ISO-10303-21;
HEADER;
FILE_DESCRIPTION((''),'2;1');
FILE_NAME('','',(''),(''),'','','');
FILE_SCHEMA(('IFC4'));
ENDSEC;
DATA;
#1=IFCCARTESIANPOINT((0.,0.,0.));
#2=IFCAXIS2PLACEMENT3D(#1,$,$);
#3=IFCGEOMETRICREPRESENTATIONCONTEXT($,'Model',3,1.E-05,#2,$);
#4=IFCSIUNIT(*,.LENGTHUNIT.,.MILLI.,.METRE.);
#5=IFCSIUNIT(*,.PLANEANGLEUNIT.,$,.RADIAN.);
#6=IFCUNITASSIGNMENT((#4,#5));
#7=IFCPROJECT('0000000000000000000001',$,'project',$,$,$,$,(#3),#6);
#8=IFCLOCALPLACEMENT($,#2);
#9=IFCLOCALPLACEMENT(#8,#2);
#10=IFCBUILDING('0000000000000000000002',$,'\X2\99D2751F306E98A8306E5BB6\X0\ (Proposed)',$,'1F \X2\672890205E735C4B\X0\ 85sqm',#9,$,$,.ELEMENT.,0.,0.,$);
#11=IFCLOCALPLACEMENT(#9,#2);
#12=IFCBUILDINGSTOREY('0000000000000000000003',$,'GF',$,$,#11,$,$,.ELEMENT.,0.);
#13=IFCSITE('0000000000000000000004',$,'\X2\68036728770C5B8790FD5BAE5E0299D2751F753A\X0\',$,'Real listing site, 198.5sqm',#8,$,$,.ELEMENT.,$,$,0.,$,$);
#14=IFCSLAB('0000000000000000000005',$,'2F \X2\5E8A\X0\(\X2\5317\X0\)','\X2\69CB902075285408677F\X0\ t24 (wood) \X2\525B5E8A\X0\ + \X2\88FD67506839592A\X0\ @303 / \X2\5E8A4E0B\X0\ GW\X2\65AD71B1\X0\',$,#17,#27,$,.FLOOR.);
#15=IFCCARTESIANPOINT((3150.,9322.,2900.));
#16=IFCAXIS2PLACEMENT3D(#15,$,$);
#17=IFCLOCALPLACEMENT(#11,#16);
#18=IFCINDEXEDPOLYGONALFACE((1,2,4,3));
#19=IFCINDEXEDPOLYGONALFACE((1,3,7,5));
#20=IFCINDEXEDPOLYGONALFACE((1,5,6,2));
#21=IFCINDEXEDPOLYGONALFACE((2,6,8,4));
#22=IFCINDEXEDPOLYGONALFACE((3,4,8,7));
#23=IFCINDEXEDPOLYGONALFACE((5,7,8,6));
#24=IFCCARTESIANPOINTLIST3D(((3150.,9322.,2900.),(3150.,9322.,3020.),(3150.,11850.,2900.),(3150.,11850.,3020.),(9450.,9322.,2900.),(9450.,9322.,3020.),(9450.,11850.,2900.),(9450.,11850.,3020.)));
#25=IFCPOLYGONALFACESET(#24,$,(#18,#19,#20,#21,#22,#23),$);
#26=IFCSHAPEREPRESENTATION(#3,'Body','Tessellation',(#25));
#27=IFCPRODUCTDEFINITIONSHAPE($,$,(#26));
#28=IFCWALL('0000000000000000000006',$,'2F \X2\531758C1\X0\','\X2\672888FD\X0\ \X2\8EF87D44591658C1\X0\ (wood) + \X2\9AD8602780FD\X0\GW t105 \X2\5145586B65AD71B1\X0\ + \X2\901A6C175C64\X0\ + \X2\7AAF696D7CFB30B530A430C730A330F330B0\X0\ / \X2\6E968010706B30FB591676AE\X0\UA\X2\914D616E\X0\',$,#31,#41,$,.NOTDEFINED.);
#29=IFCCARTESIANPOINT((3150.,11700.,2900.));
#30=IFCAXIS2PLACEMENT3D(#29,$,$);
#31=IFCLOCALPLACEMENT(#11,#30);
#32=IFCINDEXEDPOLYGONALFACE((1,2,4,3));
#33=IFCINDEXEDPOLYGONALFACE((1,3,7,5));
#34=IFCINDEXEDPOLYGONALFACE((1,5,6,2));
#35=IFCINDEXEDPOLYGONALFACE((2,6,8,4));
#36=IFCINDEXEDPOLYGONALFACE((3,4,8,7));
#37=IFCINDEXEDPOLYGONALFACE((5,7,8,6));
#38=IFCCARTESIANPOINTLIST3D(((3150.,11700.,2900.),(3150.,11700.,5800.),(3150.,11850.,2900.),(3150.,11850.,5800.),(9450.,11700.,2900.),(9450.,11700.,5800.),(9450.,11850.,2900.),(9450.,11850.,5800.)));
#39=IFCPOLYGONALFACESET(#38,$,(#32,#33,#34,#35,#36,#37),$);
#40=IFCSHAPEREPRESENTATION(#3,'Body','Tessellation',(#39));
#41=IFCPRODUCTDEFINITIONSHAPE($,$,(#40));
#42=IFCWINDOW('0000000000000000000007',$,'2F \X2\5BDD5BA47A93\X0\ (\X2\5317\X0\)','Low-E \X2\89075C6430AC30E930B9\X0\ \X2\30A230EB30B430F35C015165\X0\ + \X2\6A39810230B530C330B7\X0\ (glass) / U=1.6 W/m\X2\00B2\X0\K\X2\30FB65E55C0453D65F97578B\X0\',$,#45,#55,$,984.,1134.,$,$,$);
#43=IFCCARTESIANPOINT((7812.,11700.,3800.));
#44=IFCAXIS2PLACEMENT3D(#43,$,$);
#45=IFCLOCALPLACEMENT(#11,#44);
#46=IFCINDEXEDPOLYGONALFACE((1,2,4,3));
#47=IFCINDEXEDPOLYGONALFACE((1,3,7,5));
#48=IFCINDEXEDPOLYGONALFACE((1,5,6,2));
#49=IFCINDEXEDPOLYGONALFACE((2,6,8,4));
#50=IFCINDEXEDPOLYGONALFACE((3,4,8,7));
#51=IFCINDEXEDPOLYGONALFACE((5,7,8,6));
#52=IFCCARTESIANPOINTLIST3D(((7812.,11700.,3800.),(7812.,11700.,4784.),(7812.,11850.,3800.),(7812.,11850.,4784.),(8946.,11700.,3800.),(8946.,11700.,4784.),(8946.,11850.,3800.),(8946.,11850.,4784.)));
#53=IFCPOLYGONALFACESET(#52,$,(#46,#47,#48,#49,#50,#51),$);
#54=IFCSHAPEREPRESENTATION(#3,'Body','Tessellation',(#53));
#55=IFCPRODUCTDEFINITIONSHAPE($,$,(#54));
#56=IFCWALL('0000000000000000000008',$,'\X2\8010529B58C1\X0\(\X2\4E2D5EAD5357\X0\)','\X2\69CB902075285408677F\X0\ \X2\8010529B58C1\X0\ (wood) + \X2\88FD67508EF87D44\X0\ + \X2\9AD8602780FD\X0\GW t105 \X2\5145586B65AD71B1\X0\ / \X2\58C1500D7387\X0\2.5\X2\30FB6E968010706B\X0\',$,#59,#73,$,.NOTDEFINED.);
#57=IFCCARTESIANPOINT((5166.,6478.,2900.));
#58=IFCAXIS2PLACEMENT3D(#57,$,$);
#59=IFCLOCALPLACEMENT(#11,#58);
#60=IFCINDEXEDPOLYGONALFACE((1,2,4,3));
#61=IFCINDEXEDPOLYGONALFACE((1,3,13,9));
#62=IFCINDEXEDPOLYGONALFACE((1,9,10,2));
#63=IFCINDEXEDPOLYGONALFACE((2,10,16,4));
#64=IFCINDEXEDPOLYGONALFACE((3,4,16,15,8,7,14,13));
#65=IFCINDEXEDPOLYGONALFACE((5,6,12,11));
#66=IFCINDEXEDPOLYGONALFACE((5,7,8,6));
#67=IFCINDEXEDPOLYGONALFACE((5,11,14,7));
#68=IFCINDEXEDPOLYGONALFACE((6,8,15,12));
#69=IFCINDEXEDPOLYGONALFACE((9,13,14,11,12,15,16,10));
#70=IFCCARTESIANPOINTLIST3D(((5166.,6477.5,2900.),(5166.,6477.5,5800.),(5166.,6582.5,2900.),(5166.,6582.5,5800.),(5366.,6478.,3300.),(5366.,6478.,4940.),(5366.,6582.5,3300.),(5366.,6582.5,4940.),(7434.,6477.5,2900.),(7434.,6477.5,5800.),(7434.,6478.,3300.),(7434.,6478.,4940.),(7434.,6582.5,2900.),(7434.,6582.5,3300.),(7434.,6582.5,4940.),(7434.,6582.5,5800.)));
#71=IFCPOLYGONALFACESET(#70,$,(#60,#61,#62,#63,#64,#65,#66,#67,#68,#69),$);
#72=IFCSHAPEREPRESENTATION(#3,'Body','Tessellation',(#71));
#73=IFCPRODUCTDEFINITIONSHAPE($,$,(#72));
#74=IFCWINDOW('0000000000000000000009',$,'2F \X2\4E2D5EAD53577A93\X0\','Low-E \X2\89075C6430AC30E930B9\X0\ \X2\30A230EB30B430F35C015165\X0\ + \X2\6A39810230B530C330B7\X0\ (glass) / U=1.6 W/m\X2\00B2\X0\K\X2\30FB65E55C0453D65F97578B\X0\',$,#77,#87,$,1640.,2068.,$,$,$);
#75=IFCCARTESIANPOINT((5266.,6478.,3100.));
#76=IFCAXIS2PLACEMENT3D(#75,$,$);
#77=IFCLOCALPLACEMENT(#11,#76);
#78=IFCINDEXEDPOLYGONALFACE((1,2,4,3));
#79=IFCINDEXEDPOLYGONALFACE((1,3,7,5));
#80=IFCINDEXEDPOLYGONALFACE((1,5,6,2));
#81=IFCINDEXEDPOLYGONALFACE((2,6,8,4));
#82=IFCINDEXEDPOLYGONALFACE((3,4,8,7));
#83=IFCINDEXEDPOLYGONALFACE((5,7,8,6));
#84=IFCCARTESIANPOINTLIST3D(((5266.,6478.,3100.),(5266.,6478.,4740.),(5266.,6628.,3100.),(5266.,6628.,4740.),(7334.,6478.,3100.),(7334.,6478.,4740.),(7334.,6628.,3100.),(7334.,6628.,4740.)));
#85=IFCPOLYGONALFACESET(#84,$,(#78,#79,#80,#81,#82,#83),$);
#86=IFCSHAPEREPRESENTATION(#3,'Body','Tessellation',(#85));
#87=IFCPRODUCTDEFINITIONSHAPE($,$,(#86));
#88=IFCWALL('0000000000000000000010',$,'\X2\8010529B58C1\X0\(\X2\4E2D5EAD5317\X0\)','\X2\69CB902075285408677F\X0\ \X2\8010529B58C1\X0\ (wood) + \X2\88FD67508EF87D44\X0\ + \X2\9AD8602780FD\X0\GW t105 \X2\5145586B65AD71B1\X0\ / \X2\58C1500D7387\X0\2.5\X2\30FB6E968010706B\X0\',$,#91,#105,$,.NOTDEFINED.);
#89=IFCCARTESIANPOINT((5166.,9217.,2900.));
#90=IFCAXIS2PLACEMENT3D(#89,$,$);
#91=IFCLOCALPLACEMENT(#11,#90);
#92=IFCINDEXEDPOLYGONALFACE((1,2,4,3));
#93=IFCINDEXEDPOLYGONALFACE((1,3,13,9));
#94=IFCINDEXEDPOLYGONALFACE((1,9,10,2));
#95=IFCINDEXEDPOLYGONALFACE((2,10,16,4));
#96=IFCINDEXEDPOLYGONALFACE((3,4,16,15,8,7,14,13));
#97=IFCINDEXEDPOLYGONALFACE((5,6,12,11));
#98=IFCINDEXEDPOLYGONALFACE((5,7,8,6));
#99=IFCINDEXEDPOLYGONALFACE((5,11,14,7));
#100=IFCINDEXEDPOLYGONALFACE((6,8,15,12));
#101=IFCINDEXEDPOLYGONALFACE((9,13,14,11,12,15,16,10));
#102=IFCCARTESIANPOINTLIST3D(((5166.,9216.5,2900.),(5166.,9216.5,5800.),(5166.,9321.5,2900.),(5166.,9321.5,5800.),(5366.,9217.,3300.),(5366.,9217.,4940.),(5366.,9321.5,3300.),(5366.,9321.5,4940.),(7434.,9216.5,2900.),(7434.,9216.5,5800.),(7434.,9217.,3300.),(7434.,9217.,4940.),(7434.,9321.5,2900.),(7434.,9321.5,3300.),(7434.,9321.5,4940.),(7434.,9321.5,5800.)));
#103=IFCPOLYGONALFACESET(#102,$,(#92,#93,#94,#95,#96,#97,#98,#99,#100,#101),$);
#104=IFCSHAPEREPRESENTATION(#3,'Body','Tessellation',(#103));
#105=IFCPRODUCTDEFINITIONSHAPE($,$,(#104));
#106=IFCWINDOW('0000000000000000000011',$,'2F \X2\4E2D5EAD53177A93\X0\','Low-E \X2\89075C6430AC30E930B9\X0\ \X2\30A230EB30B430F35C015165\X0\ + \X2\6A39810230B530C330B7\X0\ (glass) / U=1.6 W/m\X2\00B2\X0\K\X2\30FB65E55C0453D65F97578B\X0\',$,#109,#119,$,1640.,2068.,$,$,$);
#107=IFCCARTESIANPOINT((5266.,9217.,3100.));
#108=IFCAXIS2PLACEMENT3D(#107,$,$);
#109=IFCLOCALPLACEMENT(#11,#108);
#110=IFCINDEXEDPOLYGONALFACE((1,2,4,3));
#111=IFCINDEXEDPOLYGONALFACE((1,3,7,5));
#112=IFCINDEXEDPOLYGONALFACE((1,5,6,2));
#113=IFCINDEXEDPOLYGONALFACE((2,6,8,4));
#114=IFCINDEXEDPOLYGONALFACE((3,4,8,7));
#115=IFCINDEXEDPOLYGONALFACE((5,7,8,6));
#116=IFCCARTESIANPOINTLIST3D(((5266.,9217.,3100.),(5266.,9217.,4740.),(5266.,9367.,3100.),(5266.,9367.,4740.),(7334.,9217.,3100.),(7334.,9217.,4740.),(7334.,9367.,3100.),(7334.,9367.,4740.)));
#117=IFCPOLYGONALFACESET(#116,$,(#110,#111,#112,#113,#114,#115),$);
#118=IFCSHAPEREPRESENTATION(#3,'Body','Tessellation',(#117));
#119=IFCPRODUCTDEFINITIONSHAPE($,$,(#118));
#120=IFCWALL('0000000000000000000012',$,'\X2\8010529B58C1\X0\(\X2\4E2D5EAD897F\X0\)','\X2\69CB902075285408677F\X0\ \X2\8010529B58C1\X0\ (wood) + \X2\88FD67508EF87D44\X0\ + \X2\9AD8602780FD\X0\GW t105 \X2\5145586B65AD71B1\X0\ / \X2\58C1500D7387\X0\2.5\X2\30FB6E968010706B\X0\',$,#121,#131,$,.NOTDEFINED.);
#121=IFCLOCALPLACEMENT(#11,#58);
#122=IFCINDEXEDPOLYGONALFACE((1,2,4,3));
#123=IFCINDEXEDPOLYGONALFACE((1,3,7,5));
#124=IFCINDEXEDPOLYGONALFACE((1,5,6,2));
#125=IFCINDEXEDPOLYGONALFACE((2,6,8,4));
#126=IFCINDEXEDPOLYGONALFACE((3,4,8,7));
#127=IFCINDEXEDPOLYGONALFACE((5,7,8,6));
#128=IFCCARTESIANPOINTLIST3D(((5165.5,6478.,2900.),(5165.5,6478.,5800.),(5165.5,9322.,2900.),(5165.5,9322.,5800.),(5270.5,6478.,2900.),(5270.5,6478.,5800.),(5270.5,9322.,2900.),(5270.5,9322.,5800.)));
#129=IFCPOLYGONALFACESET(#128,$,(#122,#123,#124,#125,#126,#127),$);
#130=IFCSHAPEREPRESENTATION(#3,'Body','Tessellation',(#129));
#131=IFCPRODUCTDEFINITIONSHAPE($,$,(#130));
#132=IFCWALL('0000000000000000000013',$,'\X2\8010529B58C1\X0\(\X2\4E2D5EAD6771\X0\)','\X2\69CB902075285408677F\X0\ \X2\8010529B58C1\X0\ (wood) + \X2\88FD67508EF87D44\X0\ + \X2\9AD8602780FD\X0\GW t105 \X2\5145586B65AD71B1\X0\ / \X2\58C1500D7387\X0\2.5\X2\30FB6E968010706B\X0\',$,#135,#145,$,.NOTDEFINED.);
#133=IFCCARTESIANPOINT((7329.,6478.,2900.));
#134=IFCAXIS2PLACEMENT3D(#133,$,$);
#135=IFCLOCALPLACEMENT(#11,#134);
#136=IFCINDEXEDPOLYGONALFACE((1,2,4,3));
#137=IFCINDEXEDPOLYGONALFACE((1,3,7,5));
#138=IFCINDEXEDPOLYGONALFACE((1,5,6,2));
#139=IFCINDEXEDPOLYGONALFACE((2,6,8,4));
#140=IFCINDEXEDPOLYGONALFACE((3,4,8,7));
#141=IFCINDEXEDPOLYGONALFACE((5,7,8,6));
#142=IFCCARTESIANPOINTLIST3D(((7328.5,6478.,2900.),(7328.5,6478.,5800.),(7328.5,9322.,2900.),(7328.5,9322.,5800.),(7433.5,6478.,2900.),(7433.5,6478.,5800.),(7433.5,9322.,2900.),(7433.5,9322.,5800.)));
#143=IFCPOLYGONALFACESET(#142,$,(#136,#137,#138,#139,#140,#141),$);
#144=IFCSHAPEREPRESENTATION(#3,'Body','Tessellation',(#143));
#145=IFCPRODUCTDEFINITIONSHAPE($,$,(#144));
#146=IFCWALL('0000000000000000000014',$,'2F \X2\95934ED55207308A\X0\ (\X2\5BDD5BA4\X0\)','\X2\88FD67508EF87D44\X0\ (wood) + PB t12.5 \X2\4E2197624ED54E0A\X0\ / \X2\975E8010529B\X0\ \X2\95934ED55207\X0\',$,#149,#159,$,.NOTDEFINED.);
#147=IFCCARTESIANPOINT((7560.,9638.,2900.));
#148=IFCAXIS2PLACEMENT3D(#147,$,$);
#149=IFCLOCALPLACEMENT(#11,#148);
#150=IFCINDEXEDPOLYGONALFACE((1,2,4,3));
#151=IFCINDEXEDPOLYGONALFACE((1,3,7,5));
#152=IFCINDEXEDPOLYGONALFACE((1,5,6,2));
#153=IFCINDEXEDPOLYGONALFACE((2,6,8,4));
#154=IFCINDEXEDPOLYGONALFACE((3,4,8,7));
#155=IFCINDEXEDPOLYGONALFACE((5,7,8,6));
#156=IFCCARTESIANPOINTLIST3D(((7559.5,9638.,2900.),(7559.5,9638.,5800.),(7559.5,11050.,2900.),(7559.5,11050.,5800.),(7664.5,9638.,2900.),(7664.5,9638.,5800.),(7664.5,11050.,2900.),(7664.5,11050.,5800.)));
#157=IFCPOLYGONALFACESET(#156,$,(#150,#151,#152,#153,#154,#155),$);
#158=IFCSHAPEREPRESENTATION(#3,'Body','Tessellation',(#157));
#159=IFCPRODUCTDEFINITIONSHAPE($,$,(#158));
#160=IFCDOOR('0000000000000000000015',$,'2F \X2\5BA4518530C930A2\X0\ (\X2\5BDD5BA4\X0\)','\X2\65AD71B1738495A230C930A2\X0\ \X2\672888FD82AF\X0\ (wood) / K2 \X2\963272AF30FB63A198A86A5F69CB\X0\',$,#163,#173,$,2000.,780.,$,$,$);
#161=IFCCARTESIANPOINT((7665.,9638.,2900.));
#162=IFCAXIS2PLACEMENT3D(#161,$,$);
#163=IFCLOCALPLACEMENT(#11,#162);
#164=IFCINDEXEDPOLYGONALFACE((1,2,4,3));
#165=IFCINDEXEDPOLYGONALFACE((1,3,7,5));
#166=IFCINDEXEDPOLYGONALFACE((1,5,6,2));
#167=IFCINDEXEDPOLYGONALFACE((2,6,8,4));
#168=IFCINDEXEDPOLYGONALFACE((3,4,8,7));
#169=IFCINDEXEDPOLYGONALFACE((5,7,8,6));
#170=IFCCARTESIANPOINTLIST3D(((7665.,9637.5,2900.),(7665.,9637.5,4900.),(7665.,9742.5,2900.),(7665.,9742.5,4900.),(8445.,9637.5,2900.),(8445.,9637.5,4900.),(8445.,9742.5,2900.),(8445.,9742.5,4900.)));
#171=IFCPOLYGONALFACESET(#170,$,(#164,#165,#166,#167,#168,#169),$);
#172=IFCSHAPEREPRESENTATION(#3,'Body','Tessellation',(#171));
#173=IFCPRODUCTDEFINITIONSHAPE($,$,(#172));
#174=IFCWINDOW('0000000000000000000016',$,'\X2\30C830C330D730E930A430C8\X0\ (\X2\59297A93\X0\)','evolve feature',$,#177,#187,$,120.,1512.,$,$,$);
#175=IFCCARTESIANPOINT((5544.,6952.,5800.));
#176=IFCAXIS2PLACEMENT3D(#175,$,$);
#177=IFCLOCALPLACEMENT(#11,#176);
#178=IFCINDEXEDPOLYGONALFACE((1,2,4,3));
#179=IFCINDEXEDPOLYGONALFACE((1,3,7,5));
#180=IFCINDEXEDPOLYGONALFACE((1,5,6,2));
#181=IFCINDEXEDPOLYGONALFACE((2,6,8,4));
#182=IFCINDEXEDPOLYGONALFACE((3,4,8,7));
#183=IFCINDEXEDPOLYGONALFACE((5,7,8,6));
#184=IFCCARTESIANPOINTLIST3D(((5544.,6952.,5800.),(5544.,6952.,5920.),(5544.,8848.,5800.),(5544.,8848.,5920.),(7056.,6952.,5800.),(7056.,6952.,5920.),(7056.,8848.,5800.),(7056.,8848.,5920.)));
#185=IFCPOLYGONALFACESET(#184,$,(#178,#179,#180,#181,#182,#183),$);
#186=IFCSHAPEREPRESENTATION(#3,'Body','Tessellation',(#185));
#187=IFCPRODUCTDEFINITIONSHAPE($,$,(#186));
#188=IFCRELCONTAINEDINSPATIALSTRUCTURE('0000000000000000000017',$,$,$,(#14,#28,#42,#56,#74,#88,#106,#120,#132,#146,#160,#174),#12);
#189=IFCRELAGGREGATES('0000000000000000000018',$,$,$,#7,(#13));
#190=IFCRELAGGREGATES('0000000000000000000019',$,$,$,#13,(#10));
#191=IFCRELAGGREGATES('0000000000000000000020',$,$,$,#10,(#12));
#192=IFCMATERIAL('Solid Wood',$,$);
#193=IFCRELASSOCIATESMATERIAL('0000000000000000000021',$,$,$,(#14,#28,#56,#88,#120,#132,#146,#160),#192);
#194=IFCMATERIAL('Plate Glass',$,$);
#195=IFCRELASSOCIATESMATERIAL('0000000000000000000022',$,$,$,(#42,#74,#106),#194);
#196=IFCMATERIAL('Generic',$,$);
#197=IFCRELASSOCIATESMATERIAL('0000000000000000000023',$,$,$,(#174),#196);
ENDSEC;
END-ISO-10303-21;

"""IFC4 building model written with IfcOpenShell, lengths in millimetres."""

from ifc_helpers import new_model, si_unit, frame, frame_2d, origin, place, context, project, spatial, rectangle, extrude, material, element, fill, save


model = new_model("IFC4")

# Units and contexts
model_context = context("Model", 3, precision=1e-05, world=origin())
ifc_project = project(units=[si_unit("LENGTHUNIT", "METRE", prefix="MILLI"), si_unit("PLANEANGLEUNIT", "RADIAN")], contexts=[model_context])

# Site, building, storey
site_placement = place(None, origin())
site = spatial("IfcSite", under=ifc_project, at=site_placement, Name="栃木県宇都宮市駒生町", ObjectType="Real listing site, 198.5sqm", CompositionType="ELEMENT", RefElevation=0.0)
building_placement = place(site_placement, origin())
building = spatial("IfcBuilding", under=site, at=building_placement, Name="駒生の風の家 (Proposed)", ObjectType="1F 木造平屋 85sqm", CompositionType="ELEMENT", ElevationOfRefHeight=0.0, ElevationOfTerrain=0.0)
storey_placement = place(building_placement, origin())
storey = spatial("IfcBuildingStorey", under=building, at=storey_placement, Name="GF", CompositionType="ELEMENT", Elevation=0.0)

# Slab
ifc_material_1 = material(Name="Solid Wood")
slab_placement = place(storey_placement, frame((3150.0, 9322.0, 2900.0)))
element("IfcSlab", 1, at=slab_placement, inside=storey, material=ifc_material_1, Name="2F 床(北)", Description="構造用合板 t24 (wood) 剛床 + 製材根太 @303 / 床下 GW断熱", PredefinedType="FLOOR", context=model_context, shape_type="SweptSolid", body=[
    extrude(rectangle(XDim=6300.0, YDim=2528.0, at=frame_2d((3150.0, 1264.0))), frame((3150.0, 9322.0, 2900.0)), (0.0, 0.0, 1.0), 120.0),
])

# Walls, openings, windows
wall_1_placement = place(storey_placement, frame((3150.0, 11700.0, 2900.0)))
wall_1 = element("IfcWall", 2, at=wall_1_placement, inside=storey, material=ifc_material_1, Name="2F 北壁", Description="木製 軸組外壁 (wood) + 高性能GW t105 充填断熱 + 通気層 + 窯業系サイディング / 準耐火・外皮UA配慮", PredefinedType="NOTDEFINED", context=model_context, shape_type="SweptSolid", body=[
    extrude(rectangle(XDim=6300.0, YDim=150.0, at=frame_2d((3150.0, 75.0))), frame((3150.0, 11700.0, 2900.0)), (0.0, 0.0, 1.0), 2900.0),
])
opening_1_placement = place(storey_placement, frame((7812.0, 11700.0, 3800.0)))
opening_1 = element("IfcOpeningElement", 3, at=opening_1_placement, cuts=wall_1, PredefinedType="NOTDEFINED", context=model_context, shape_type="SweptSolid", body=[
    extrude(rectangle(XDim=1134.0, YDim=150.0, at=frame_2d((567.0, 75.0))), frame((7812.0, 11700.0, 3800.0)), (0.0, 0.0, 1.0), 984.0),
])
ifc_material_2 = material(Name="Plate Glass")
window_1_placement = place(storey_placement, frame((7812.0, 11700.0, 3800.0)))
window_1 = element("IfcWindow", 4, at=window_1_placement, inside=storey, material=ifc_material_2, Name="2F 寝室窓 (北)", Description="Low-E 複層ガラス アルゴン封入 + 樹脂サッシ (glass) / U=1.6 W/m²K・日射取得型", OverallHeight=984.0, OverallWidth=1134.0, context=model_context, shape_type="SweptSolid", body=[
    extrude(rectangle(XDim=1134.0, YDim=150.0, at=frame_2d((567.0, 75.0))), frame((7812.0, 11700.0, 3800.0)), (0.0, 0.0, 1.0), 984.0),
])
fill(opening_1, window_1)
wall_2_placement = place(storey_placement, frame((5166.0, 6478.0, 2900.0)))
wall_2 = element("IfcWall", 5, at=wall_2_placement, inside=storey, material=ifc_material_1, Name="耐力壁(中庭南)", Description="構造用合板 耐力壁 (wood) + 製材軸組 + 高性能GW t105 充填断熱 / 壁倍率2.5・準耐火", PredefinedType="NOTDEFINED", context=model_context, shape_type="SweptSolid", body=[
    extrude(rectangle(XDim=2268.0, YDim=105.0, at=frame_2d((1134.0, 52.0))), frame((5166.0, 6478.0, 2900.0)), (0.0, 0.0, 1.0), 2900.0),
])
opening_2_placement = place(storey_placement, frame((5266.0, 6478.0, 3100.0)))
opening_2 = element("IfcOpeningElement", 6, at=opening_2_placement, cuts=wall_2, PredefinedType="NOTDEFINED", context=model_context, shape_type="SweptSolid", body=[
    extrude(rectangle(XDim=2068.0, YDim=150.0, at=frame_2d((1034.0, 75.0))), frame((5266.0, 6478.0, 3100.0)), (0.0, 0.0, 1.0), 1640.0),
])
window_2_placement = place(storey_placement, frame((5266.0, 6478.0, 3100.0)))
window_2 = element("IfcWindow", 7, at=window_2_placement, inside=storey, material=ifc_material_2, Name="2F 中庭南窓", Description="Low-E 複層ガラス アルゴン封入 + 樹脂サッシ (glass) / U=1.6 W/m²K・日射取得型", OverallHeight=1640.0, OverallWidth=2068.0, context=model_context, shape_type="SweptSolid", body=[
    extrude(rectangle(XDim=2068.0, YDim=150.0, at=frame_2d((1034.0, 75.0))), frame((5266.0, 6478.0, 3100.0)), (0.0, 0.0, 1.0), 1640.0),
])
fill(opening_2, window_2)
wall_3_placement = place(storey_placement, frame((5166.0, 9217.0, 2900.0)))
wall_3 = element("IfcWall", 8, at=wall_3_placement, inside=storey, material=ifc_material_1, Name="耐力壁(中庭北)", Description="構造用合板 耐力壁 (wood) + 製材軸組 + 高性能GW t105 充填断熱 / 壁倍率2.5・準耐火", PredefinedType="NOTDEFINED", context=model_context, shape_type="SweptSolid", body=[
    extrude(rectangle(XDim=2268.0, YDim=105.0, at=frame_2d((1134.0, 52.0))), frame((5166.0, 9217.0, 2900.0)), (0.0, 0.0, 1.0), 2900.0),
])
opening_3_placement = place(storey_placement, frame((5266.0, 9217.0, 3100.0)))
opening_3 = element("IfcOpeningElement", 9, at=opening_3_placement, cuts=wall_3, PredefinedType="NOTDEFINED", context=model_context, shape_type="SweptSolid", body=[
    extrude(rectangle(XDim=2068.0, YDim=150.0, at=frame_2d((1034.0, 75.0))), frame((5266.0, 9217.0, 3100.0)), (0.0, 0.0, 1.0), 1640.0),
])
window_3_placement = place(storey_placement, frame((5266.0, 9217.0, 3100.0)))
window_3 = element("IfcWindow", 10, at=window_3_placement, inside=storey, material=ifc_material_2, Name="2F 中庭北窓", Description="Low-E 複層ガラス アルゴン封入 + 樹脂サッシ (glass) / U=1.6 W/m²K・日射取得型", OverallHeight=1640.0, OverallWidth=2068.0, context=model_context, shape_type="SweptSolid", body=[
    extrude(rectangle(XDim=2068.0, YDim=150.0, at=frame_2d((1034.0, 75.0))), frame((5266.0, 9217.0, 3100.0)), (0.0, 0.0, 1.0), 1640.0),
])
fill(opening_3, window_3)

# Walls
wall_4_placement = place(storey_placement, frame((5166.0, 6478.0, 2900.0)))
element("IfcWall", 11, at=wall_4_placement, inside=storey, material=ifc_material_1, Name="耐力壁(中庭西)", Description="構造用合板 耐力壁 (wood) + 製材軸組 + 高性能GW t105 充填断熱 / 壁倍率2.5・準耐火", PredefinedType="NOTDEFINED", context=model_context, shape_type="SweptSolid", body=[
    extrude(rectangle(XDim=105.0, YDim=2844.0, at=frame_2d((52.0, 1422.0))), frame((5166.0, 6478.0, 2900.0)), (0.0, 0.0, 1.0), 2900.0),
])
wall_5_placement = place(storey_placement, frame((7329.0, 6478.0, 2900.0)))
element("IfcWall", 12, at=wall_5_placement, inside=storey, material=ifc_material_1, Name="耐力壁(中庭東)", Description="構造用合板 耐力壁 (wood) + 製材軸組 + 高性能GW t105 充填断熱 / 壁倍率2.5・準耐火", PredefinedType="NOTDEFINED", context=model_context, shape_type="SweptSolid", body=[
    extrude(rectangle(XDim=105.0, YDim=2844.0, at=frame_2d((52.0, 1422.0))), frame((7329.0, 6478.0, 2900.0)), (0.0, 0.0, 1.0), 2900.0),
])
wall_6_placement = place(storey_placement, frame((7560.0, 9638.0, 2900.0)))
element("IfcWall", 13, at=wall_6_placement, inside=storey, material=ifc_material_1, Name="2F 間仕切り (寝室)", Description="製材軸組 (wood) + PB t12.5 両面仕上 / 非耐力 間仕切", PredefinedType="NOTDEFINED", context=model_context, shape_type="SweptSolid", body=[
    extrude(rectangle(XDim=105.0, YDim=1412.0, at=frame_2d((52.0, 706.0))), frame((7560.0, 9638.0, 2900.0)), (0.0, 0.0, 1.0), 2900.0),
])

# Door
door_placement = place(storey_placement, frame((7665.0, 9638.0, 2900.0)))
element("IfcDoor", 14, at=door_placement, inside=storey, material=ifc_material_1, Name="2F 室内ドア (寝室)", Description="断熱玄関ドア 木製芯 (wood) / K2 防犯・採風機構", OverallHeight=2000.0, OverallWidth=780.0, context=model_context, shape_type="SweptSolid", body=[
    extrude(rectangle(XDim=780.0, YDim=105.0, at=frame_2d((390.0, 52.0))), frame((7665.0, 9638.0, 2900.0)), (0.0, 0.0, 1.0), 2000.0),
])

# Window
ifc_material_3 = material(Name="Generic")
window_4_placement = place(storey_placement, frame((5544.0, 6952.0, 5800.0)))
element("IfcWindow", 15, at=window_4_placement, inside=storey, material=ifc_material_3, Name="トップライト (天窓)", Description="evolve feature", OverallHeight=120.0, OverallWidth=1512.0, context=model_context, shape_type="SweptSolid", body=[
    extrude(rectangle(XDim=1512.0, YDim=1896.0, at=frame_2d((756.0, 948.0))), frame((5544.0, 6952.0, 5800.0)), (0.0, 0.0, 1.0), 120.0),
])

save(model, "model.ifc")
